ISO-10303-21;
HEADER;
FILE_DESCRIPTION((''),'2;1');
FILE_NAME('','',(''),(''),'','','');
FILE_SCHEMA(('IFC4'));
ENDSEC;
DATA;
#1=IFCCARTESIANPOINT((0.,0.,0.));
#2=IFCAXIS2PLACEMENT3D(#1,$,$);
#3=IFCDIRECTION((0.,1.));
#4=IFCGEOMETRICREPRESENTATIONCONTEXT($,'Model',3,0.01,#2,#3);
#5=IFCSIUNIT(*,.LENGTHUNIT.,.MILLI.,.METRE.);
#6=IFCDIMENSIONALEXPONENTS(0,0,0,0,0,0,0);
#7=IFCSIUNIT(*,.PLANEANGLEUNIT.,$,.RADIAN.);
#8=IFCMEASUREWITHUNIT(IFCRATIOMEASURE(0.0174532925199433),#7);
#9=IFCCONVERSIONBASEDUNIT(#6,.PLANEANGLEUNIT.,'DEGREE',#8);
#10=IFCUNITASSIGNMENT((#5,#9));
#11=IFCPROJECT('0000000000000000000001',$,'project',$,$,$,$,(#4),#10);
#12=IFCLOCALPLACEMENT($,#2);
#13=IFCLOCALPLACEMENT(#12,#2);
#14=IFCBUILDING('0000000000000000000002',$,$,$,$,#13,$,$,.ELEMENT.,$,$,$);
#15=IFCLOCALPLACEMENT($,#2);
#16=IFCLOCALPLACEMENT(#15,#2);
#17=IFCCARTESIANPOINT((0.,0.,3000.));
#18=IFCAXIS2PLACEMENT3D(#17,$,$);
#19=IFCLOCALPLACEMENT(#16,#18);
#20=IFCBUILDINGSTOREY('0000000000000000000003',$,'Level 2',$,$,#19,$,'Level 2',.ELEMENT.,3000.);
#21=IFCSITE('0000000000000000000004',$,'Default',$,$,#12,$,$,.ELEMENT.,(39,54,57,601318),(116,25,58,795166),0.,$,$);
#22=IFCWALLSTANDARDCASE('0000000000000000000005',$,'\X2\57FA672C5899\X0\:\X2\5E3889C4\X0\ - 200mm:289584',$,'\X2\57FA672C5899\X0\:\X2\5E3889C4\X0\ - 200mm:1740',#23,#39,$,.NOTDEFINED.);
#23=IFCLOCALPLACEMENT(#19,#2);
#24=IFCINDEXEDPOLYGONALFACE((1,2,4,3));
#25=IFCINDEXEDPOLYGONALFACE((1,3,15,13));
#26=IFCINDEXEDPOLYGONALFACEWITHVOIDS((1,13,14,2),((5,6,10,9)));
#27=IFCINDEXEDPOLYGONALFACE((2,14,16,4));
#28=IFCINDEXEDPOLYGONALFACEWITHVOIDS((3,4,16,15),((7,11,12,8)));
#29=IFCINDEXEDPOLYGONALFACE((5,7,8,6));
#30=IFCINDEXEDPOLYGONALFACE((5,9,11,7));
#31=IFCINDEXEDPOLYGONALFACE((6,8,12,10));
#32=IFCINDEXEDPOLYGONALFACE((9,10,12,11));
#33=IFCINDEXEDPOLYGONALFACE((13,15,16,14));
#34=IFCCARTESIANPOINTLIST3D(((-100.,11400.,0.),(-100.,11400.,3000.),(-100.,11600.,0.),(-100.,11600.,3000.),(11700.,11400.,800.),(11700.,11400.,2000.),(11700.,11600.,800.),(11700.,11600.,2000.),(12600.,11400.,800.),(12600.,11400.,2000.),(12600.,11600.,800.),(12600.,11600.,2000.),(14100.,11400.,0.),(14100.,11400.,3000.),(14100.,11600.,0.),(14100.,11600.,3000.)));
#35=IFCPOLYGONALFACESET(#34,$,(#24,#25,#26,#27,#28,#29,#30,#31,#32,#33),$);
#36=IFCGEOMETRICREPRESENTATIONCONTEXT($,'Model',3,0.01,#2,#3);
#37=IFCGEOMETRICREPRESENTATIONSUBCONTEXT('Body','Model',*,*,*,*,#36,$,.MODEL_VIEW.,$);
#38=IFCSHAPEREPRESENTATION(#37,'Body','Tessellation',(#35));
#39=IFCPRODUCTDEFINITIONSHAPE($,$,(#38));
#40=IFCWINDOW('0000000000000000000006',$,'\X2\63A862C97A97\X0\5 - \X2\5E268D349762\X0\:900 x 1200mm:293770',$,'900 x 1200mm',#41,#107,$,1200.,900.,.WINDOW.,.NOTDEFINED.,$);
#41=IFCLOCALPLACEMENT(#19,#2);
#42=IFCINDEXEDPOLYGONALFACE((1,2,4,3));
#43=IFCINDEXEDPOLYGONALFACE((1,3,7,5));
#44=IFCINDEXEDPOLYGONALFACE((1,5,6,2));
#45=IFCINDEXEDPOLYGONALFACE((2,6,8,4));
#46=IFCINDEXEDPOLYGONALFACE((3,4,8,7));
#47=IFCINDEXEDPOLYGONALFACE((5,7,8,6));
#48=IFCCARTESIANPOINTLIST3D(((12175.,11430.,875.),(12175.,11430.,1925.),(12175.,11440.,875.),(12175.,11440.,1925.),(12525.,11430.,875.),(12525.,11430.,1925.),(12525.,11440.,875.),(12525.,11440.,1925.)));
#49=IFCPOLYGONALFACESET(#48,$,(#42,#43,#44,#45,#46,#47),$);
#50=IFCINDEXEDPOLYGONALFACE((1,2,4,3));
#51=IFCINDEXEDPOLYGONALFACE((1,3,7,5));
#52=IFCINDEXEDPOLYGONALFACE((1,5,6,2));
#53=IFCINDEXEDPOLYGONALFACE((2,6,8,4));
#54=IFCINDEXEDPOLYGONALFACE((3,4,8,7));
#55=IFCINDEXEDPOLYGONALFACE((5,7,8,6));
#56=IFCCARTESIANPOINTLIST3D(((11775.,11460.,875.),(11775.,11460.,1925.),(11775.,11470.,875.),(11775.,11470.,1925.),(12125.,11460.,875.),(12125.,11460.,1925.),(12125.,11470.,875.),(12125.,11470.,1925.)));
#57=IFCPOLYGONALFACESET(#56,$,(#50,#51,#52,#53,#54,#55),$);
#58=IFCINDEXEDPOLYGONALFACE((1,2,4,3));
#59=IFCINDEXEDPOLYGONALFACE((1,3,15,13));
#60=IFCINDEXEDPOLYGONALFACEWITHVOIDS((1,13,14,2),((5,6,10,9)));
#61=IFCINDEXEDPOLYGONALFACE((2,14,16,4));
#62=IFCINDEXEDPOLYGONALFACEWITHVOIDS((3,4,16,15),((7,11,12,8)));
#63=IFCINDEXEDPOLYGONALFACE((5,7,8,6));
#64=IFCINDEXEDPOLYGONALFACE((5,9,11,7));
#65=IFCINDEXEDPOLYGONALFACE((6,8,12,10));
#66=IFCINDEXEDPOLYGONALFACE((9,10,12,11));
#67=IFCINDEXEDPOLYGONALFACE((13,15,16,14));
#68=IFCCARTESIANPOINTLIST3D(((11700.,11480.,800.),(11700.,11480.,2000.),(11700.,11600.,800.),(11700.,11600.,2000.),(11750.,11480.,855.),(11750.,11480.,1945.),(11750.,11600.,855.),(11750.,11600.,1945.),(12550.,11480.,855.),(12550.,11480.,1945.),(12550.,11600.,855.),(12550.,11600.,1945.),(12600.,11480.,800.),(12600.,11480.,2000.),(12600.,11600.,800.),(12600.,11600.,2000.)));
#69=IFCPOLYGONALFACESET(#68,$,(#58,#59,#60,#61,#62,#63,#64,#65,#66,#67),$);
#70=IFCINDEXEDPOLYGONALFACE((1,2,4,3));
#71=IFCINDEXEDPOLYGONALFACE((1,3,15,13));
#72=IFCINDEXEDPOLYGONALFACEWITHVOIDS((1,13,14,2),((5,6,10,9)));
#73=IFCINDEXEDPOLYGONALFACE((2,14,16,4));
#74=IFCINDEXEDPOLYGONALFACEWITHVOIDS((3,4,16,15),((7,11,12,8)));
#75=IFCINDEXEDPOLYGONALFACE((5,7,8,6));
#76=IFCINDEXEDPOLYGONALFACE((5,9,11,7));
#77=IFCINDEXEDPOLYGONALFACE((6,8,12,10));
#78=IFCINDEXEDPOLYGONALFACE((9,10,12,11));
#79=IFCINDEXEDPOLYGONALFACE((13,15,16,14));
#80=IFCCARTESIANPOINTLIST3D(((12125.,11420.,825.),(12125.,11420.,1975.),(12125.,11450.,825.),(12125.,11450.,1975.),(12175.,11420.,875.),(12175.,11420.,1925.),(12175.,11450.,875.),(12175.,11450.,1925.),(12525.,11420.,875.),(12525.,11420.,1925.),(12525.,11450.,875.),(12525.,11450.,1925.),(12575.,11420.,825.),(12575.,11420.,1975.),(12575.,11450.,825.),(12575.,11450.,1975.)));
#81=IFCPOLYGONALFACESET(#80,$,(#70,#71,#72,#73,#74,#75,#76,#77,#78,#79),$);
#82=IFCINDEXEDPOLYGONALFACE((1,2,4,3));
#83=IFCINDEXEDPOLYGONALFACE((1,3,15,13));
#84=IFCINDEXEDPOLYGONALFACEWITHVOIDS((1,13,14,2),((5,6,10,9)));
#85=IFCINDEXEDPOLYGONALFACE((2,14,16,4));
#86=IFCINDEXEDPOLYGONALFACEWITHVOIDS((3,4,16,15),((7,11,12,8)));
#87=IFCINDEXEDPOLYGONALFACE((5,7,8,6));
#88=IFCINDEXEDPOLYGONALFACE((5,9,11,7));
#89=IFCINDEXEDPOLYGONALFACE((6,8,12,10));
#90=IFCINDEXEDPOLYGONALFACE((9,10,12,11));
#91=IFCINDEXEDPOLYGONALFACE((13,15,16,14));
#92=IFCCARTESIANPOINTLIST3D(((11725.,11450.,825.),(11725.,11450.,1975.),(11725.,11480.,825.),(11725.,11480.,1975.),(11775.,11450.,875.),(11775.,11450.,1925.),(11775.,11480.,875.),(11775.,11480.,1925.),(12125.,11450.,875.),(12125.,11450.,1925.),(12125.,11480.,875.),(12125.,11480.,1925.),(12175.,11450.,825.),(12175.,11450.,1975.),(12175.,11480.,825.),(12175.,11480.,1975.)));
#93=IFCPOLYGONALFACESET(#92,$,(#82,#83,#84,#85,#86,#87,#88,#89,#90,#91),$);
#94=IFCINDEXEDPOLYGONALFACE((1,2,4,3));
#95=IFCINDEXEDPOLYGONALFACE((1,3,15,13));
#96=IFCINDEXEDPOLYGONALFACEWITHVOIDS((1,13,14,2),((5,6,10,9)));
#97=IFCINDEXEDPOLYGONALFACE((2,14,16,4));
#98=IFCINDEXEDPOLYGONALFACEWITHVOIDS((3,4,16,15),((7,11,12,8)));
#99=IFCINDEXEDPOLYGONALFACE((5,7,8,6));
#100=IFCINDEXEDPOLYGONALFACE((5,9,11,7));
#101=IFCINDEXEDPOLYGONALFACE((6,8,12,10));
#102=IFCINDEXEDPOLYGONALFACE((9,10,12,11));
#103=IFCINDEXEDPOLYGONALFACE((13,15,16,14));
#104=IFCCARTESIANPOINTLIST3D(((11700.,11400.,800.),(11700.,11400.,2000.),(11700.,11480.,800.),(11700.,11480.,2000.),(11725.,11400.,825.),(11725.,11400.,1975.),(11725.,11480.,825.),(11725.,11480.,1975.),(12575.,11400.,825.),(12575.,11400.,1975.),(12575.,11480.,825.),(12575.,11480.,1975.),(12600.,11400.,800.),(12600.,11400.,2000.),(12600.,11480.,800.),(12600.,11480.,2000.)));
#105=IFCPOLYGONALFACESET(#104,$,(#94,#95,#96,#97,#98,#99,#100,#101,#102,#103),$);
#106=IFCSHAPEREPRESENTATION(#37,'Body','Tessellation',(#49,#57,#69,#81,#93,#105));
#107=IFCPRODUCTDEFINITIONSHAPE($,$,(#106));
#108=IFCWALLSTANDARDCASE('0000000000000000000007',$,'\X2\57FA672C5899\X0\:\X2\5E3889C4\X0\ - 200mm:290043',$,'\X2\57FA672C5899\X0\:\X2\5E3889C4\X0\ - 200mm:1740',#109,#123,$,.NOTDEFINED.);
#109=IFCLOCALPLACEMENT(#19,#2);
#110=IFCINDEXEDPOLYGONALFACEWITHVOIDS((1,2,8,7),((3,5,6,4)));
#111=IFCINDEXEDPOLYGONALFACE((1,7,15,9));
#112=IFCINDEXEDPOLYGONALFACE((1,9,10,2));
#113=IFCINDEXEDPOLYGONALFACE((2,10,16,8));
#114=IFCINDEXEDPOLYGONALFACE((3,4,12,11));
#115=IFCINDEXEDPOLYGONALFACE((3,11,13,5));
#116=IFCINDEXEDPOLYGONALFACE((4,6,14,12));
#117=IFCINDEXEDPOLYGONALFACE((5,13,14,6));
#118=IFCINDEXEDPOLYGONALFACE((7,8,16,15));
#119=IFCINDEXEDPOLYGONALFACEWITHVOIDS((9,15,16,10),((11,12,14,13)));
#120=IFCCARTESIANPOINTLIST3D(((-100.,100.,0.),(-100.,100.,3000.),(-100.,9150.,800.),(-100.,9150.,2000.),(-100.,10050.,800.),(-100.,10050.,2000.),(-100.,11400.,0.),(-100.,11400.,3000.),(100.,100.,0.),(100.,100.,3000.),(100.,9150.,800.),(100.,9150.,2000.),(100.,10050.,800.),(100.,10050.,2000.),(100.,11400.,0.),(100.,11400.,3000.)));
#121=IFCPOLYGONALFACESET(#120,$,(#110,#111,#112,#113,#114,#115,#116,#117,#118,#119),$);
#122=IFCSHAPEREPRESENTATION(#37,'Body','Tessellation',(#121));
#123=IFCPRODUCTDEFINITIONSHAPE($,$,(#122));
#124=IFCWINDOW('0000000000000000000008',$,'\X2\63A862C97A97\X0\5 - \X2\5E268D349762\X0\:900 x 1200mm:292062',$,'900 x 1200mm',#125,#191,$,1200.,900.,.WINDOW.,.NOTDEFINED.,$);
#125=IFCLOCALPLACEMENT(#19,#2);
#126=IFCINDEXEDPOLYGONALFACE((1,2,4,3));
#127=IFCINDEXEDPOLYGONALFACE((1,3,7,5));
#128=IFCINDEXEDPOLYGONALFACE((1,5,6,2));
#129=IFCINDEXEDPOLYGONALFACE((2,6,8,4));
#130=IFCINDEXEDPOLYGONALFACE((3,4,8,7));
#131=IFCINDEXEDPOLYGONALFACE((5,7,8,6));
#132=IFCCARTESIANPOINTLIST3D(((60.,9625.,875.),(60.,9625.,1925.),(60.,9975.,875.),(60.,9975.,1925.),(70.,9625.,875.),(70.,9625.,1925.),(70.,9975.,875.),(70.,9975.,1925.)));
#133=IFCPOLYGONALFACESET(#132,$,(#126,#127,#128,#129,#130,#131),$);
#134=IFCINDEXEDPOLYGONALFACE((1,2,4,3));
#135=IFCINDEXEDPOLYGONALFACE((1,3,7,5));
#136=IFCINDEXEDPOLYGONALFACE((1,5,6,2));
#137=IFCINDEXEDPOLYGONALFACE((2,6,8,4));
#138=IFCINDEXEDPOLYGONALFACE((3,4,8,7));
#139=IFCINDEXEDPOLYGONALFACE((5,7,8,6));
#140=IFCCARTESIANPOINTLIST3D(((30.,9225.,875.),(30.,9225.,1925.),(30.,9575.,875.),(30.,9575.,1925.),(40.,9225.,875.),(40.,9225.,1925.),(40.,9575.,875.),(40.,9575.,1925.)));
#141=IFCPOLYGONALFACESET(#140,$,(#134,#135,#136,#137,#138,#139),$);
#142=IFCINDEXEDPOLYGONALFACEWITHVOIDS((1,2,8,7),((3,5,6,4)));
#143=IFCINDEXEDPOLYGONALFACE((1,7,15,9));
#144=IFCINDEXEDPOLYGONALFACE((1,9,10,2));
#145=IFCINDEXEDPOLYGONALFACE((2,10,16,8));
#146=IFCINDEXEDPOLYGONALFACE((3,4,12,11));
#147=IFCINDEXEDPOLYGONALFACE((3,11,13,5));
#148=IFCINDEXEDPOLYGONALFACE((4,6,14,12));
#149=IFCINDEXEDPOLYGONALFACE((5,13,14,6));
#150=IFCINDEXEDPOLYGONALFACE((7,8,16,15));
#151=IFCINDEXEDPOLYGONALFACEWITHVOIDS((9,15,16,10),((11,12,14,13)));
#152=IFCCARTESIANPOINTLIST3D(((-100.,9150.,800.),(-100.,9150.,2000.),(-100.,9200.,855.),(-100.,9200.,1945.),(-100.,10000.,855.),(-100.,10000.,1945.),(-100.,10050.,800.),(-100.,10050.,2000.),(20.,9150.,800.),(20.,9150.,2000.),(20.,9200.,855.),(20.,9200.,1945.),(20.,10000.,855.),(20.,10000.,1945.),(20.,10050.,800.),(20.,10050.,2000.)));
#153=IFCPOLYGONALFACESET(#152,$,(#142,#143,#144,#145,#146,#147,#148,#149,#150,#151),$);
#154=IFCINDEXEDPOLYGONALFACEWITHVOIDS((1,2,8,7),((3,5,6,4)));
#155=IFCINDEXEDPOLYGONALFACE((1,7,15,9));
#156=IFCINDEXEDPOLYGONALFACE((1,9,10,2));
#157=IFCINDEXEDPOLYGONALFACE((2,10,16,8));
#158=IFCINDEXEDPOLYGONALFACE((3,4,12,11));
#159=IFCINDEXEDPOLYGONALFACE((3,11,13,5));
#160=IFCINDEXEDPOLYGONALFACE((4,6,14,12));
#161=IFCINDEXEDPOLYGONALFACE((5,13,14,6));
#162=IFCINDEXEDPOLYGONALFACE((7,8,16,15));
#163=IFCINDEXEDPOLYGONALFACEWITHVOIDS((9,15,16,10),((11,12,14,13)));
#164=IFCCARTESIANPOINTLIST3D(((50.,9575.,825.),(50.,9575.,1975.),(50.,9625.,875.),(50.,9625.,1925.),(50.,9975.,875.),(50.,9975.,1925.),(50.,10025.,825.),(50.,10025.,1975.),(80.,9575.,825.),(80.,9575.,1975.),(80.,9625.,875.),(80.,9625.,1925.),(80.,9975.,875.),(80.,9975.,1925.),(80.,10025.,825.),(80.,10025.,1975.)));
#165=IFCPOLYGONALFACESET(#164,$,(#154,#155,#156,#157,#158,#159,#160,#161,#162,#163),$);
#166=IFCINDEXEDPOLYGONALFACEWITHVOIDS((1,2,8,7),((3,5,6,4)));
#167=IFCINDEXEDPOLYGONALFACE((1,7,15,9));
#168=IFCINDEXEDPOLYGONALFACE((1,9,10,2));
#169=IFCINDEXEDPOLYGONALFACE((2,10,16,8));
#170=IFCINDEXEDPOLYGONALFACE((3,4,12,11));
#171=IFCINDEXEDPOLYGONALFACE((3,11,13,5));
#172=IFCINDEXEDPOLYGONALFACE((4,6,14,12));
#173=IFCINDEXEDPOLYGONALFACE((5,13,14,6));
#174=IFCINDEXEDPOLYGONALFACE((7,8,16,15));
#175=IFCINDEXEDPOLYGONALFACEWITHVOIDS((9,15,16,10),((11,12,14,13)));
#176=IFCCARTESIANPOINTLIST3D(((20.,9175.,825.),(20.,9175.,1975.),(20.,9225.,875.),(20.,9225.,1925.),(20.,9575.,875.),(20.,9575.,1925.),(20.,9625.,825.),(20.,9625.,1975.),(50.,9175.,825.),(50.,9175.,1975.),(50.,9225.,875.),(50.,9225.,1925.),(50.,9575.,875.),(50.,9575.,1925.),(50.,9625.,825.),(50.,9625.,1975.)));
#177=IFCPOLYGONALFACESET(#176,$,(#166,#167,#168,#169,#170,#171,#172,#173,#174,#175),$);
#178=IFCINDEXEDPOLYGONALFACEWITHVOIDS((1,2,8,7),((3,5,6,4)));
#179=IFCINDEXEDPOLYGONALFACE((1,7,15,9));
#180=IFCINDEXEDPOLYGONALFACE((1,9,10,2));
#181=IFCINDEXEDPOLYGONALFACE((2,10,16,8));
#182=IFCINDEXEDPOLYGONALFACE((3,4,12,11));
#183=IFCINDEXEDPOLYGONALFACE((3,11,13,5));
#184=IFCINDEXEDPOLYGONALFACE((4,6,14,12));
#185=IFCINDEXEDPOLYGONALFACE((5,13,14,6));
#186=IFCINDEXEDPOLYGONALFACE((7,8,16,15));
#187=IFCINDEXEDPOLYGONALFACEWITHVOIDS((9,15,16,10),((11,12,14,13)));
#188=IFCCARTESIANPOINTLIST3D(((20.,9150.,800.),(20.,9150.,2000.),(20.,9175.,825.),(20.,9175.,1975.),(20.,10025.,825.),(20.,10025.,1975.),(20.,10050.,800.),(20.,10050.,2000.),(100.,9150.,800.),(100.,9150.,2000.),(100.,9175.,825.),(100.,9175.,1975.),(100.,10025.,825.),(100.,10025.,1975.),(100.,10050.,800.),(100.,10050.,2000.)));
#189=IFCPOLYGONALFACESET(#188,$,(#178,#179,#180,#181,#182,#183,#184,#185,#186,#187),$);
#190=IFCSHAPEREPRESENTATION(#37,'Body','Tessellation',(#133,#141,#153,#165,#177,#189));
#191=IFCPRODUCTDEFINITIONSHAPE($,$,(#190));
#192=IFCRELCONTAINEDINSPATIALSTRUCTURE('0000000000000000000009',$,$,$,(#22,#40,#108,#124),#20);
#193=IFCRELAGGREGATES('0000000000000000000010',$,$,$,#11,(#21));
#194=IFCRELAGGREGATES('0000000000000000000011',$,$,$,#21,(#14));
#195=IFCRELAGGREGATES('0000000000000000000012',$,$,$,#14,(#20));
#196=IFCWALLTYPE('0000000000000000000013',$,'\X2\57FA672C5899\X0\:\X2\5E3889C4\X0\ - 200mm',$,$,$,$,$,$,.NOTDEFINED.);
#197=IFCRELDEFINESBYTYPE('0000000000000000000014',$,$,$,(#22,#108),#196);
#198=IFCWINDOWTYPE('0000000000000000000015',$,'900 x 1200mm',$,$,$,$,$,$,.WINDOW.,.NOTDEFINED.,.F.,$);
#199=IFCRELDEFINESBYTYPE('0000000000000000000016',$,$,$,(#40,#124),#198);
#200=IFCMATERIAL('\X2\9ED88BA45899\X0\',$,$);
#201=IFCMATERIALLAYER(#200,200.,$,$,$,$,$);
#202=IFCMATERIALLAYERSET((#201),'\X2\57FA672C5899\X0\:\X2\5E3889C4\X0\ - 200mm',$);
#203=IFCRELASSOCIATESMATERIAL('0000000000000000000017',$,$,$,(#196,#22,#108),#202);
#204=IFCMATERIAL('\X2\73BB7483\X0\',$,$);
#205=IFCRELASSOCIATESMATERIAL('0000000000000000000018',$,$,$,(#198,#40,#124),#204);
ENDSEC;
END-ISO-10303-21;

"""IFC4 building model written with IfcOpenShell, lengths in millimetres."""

from ifc_helpers import new_model, entity, si_unit, converted_unit, direction, frame, frame_2d, origin, origin_2d_with_axis, place, context, subcontext, project, spatial, polyline, rectangle, outline, extrude, source, transform, mapped, material, layer, layer_set, layer_usage, type_object, type_shapes, element, fill, save


model = new_model("IFC4")

# Units and contexts
model_context_1 = context("Model", 3, precision=0.01, world=origin(), true_north=direction((0.0, 1.0)))
model_context_2 = context("Model", 3, precision=0.01, world=origin(), true_north=direction((0.0, 1.0)))
body_context = subcontext(model_context_2, "Body", "Model", "MODEL_VIEW")
ifc_project = project(units=[si_unit("LENGTHUNIT", "METRE", prefix="MILLI"), converted_unit("PLANEANGLEUNIT", "DEGREE", entity("IfcRatioMeasure", 0.0174532925199433), si_unit("PLANEANGLEUNIT", "RADIAN"), dimensions=[0, 0, 0, 0, 0, 0, 0])], contexts=[model_context_1])

# Site, building, storey
site_placement = place(None, origin())
site = spatial("IfcSite", under=ifc_project, at=site_placement, Name="Default", CompositionType="ELEMENT", RefLatitude=(39, 54, 57, 601318), RefLongitude=(116, 25, 58, 795166), RefElevation=0.0)
building_placement = place(site_placement, origin())
building = spatial("IfcBuilding", under=site, at=building_placement, CompositionType="ELEMENT")
placement_1 = place(None, origin())
placement_2 = place(placement_1, origin())
storey_placement = place(placement_2, frame((0.0, 0.0, 3000.0)))
storey = spatial("IfcBuildingStorey", under=building, at=storey_placement, Name="Level 2", LongName="Level 2", CompositionType="ELEMENT", Elevation=3000.0)

# Walls, openings, windows
ifc_material_1 = material(Name="默认墙")
ifc_layer_1 = layer(ifc_material_1, 200.0)
ifc_layer_set_1 = layer_set([ifc_layer_1], Name="基本墙:常规 - 200mm")
ifc_layer_usage_1 = layer_usage(ifc_layer_set_1, "AXIS2", "NEGATIVE", 100.0)
wall_type = type_object("IfcWallType", Name="基本墙:常规 - 200mm", PredefinedType="NOTDEFINED", material=ifc_layer_set_1)
wall_1_placement = place(storey_placement, frame((-100.0, 11500.0, 0.0)))
wall_1 = element("IfcWallStandardCase", 1, at=wall_1_placement, inside=storey, type_object=wall_type, material=ifc_layer_usage_1, Name="基本墙:常规 - 200mm:289584", ObjectType="基本墙:常规 - 200mm:1740", PredefinedType="NOTDEFINED", context=body_context, shape_type="SweptSolid", body=[
    extrude(rectangle(XDim=14200.0, YDim=200.0, at=frame_2d((7100.0, 0.0), x_axis=(-1.0, 0.0))), origin(), (0.0, 0.0, 1.0), 3000.0),
])
opening_1_placement = place(wall_1_placement, frame((12700.0, 100.0, 800.0)))
opening_1 = element("IfcOpeningElement", 2, at=opening_1_placement, cuts=wall_1, ObjectType="Opening", PredefinedType="OPENING", context=body_context, shape_type="SweptSolid", body=[
    extrude(rectangle(XDim=1200.0, YDim=900.0, at=frame_2d((600.0, 450.0), x_axis=(-1.0, 0.0))), frame((0.0, 0.0, 0.0), z_axis=(0.0, -1.0, 0.0), x_axis=(0.0, 0.0, 1.0)), (0.0, 0.0, 1.0), 200.0),
])
ifc_material_2 = material(Name="玻璃")
window_type = type_object("IfcWindowType", Name="900 x 1200mm", ParameterTakesPrecedence=False, PartitioningType="NOTDEFINED", PredefinedType="WINDOW", material=ifc_material_2)
shared_shape_1 = source(origin(), body_context, "Body", "SweptSolid", [
    extrude(rectangle(XDim=10.0, YDim=350.0, at=origin_2d_with_axis()), frame((250.0, 165.0, 75.0), z_axis=(0.0, 0.0, 1.0), x_axis=(0.0, -1.0, 0.0)), (0.0, 0.0, 1.0), 1050.0),
    extrude(rectangle(XDim=10.0, YDim=350.0, at=frame_2d((0.0, 0.0), x_axis=(1.0, 0.0))), frame((650.0, 135.0, 75.0), z_axis=(0.0, 0.0, 1.0), x_axis=(0.0, -1.0, 0.0)), (0.0, 0.0, 1.0), 1050.0),
    extrude(outline(polyline([(-450.0, -600.0), (450.0, -600.0), (450.0, 600.0), (-450.0, 600.0), (-450.0, -600.0)]), holes=[polyline([(400.0, -545.0), (-400.0, -545.0), (-400.0, 545.0), (400.0, 545.0), (400.0, -545.0)])]), frame((450.0, 0.0, 600.0), z_axis=(0.0, 1.0, 0.0), x_axis=(1.0, 0.0, 0.0)), (0.0, 0.0, 1.0), 120.0),
    extrude(outline(polyline([(-225.0, -575.0), (225.0, -575.0), (225.0, 575.0), (-225.0, 575.0), (-225.0, -575.0)]), holes=[polyline([(-175.0, -525.0), (-175.0, 525.0), (175.0, 525.0), (175.0, -525.0), (-175.0, -525.0)])]), frame((250.0, 150.0, 600.0), z_axis=(0.0, 1.0, 0.0), x_axis=(-1.0, 0.0, 0.0)), (0.0, 0.0, 1.0), 30.0),
    extrude(outline(polyline([(-225.0, -575.0), (225.0, -575.0), (225.0, 575.0), (-225.0, 575.0), (-225.0, -575.0)]), holes=[polyline([(-175.0, -525.0), (-175.0, 525.0), (175.0, 525.0), (175.0, -525.0), (-175.0, -525.0)])]), frame((650.0, 120.0, 600.0), z_axis=(0.0, 1.0, 0.0), x_axis=(1.0, 0.0, 0.0)), (0.0, 0.0, 1.0), 30.0),
    extrude(outline(polyline([(-450.0, -600.0), (450.0, -600.0), (450.0, 600.0), (-450.0, 600.0), (-450.0, -600.0)]), holes=[polyline([(-425.0, 575.0), (425.0, 575.0), (425.0, -575.0), (-425.0, -575.0), (-425.0, 575.0)])]), frame((450.0, 120.0, 600.0), z_axis=(0.0, 1.0, 0.0), x_axis=(1.0, 0.0, 0.0)), (0.0, 0.0, 1.0), 80.0),
])
type_shapes(window_type, [shared_shape_1])
window_1_placement = place(opening_1_placement, frame((0.0, 0.0, 0.0), z_axis=(0.0, 0.0, 1.0), x_axis=(-1.0, 0.0, 0.0)))
window_1 = element("IfcWindow", 3, at=window_1_placement, inside=storey, type_object=window_type, material=ifc_material_2, Name="推拉窗5 - 带贴面:900 x 1200mm:293770", ObjectType="900 x 1200mm", OverallHeight=1200.0, OverallWidth=900.0, PartitioningType="NOTDEFINED", PredefinedType="WINDOW", context=body_context, shape_type="MappedRepresentation", body=[
    mapped(shared_shape_1, transform((0.0, 0.0, 0.0), scale=1.0)),
])
fill(opening_1, window_1)
ifc_layer_usage_2 = layer_usage(ifc_layer_set_1, "AXIS2", "NEGATIVE", 100.0)
wall_2_placement = place(storey_placement, frame((0.0, 100.0, 0.0), z_axis=(0.0, 0.0, 1.0), x_axis=(0.0, 1.0, 0.0)))
wall_2 = element("IfcWallStandardCase", 4, at=wall_2_placement, inside=storey, type_object=wall_type, material=ifc_layer_usage_2, Name="基本墙:常规 - 200mm:290043", ObjectType="基本墙:常规 - 200mm:1740", PredefinedType="NOTDEFINED", context=body_context, shape_type="SweptSolid", body=[
    extrude(rectangle(XDim=11300.0, YDim=200.0, at=frame_2d((5650.0, 0.0), x_axis=(-1.0, 0.0))), origin(), (0.0, 0.0, 1.0), 3000.0),
])
opening_2_placement = place(wall_2_placement, frame((9950.0, 100.0, 800.0)))
opening_2 = element("IfcOpeningElement", 5, at=opening_2_placement, cuts=wall_2, ObjectType="Opening", PredefinedType="OPENING", context=body_context, shape_type="SweptSolid", body=[
    extrude(rectangle(XDim=1200.0, YDim=900.0, at=frame_2d((600.0, 450.0), x_axis=(-1.0, 0.0))), frame((0.0, 0.0, 0.0), z_axis=(0.0, -1.0, 0.0), x_axis=(0.0, 0.0, 1.0)), (0.0, 0.0, 1.0), 200.0),
])
window_2_placement = place(opening_2_placement, frame((0.0, 0.0, 0.0), z_axis=(0.0, 0.0, 1.0), x_axis=(-1.0, 0.0, 0.0)))
window_2 = element("IfcWindow", 6, at=window_2_placement, inside=storey, type_object=window_type, material=ifc_material_2, Name="推拉窗5 - 带贴面:900 x 1200mm:292062", ObjectType="900 x 1200mm", OverallHeight=1200.0, OverallWidth=900.0, PartitioningType="NOTDEFINED", PredefinedType="WINDOW", context=body_context, shape_type="MappedRepresentation", body=[
    mapped(shared_shape_1, transform((0.0, 0.0, 0.0), scale=1.0)),
])
fill(opening_2, window_2)

save(model, "model.ifc")
